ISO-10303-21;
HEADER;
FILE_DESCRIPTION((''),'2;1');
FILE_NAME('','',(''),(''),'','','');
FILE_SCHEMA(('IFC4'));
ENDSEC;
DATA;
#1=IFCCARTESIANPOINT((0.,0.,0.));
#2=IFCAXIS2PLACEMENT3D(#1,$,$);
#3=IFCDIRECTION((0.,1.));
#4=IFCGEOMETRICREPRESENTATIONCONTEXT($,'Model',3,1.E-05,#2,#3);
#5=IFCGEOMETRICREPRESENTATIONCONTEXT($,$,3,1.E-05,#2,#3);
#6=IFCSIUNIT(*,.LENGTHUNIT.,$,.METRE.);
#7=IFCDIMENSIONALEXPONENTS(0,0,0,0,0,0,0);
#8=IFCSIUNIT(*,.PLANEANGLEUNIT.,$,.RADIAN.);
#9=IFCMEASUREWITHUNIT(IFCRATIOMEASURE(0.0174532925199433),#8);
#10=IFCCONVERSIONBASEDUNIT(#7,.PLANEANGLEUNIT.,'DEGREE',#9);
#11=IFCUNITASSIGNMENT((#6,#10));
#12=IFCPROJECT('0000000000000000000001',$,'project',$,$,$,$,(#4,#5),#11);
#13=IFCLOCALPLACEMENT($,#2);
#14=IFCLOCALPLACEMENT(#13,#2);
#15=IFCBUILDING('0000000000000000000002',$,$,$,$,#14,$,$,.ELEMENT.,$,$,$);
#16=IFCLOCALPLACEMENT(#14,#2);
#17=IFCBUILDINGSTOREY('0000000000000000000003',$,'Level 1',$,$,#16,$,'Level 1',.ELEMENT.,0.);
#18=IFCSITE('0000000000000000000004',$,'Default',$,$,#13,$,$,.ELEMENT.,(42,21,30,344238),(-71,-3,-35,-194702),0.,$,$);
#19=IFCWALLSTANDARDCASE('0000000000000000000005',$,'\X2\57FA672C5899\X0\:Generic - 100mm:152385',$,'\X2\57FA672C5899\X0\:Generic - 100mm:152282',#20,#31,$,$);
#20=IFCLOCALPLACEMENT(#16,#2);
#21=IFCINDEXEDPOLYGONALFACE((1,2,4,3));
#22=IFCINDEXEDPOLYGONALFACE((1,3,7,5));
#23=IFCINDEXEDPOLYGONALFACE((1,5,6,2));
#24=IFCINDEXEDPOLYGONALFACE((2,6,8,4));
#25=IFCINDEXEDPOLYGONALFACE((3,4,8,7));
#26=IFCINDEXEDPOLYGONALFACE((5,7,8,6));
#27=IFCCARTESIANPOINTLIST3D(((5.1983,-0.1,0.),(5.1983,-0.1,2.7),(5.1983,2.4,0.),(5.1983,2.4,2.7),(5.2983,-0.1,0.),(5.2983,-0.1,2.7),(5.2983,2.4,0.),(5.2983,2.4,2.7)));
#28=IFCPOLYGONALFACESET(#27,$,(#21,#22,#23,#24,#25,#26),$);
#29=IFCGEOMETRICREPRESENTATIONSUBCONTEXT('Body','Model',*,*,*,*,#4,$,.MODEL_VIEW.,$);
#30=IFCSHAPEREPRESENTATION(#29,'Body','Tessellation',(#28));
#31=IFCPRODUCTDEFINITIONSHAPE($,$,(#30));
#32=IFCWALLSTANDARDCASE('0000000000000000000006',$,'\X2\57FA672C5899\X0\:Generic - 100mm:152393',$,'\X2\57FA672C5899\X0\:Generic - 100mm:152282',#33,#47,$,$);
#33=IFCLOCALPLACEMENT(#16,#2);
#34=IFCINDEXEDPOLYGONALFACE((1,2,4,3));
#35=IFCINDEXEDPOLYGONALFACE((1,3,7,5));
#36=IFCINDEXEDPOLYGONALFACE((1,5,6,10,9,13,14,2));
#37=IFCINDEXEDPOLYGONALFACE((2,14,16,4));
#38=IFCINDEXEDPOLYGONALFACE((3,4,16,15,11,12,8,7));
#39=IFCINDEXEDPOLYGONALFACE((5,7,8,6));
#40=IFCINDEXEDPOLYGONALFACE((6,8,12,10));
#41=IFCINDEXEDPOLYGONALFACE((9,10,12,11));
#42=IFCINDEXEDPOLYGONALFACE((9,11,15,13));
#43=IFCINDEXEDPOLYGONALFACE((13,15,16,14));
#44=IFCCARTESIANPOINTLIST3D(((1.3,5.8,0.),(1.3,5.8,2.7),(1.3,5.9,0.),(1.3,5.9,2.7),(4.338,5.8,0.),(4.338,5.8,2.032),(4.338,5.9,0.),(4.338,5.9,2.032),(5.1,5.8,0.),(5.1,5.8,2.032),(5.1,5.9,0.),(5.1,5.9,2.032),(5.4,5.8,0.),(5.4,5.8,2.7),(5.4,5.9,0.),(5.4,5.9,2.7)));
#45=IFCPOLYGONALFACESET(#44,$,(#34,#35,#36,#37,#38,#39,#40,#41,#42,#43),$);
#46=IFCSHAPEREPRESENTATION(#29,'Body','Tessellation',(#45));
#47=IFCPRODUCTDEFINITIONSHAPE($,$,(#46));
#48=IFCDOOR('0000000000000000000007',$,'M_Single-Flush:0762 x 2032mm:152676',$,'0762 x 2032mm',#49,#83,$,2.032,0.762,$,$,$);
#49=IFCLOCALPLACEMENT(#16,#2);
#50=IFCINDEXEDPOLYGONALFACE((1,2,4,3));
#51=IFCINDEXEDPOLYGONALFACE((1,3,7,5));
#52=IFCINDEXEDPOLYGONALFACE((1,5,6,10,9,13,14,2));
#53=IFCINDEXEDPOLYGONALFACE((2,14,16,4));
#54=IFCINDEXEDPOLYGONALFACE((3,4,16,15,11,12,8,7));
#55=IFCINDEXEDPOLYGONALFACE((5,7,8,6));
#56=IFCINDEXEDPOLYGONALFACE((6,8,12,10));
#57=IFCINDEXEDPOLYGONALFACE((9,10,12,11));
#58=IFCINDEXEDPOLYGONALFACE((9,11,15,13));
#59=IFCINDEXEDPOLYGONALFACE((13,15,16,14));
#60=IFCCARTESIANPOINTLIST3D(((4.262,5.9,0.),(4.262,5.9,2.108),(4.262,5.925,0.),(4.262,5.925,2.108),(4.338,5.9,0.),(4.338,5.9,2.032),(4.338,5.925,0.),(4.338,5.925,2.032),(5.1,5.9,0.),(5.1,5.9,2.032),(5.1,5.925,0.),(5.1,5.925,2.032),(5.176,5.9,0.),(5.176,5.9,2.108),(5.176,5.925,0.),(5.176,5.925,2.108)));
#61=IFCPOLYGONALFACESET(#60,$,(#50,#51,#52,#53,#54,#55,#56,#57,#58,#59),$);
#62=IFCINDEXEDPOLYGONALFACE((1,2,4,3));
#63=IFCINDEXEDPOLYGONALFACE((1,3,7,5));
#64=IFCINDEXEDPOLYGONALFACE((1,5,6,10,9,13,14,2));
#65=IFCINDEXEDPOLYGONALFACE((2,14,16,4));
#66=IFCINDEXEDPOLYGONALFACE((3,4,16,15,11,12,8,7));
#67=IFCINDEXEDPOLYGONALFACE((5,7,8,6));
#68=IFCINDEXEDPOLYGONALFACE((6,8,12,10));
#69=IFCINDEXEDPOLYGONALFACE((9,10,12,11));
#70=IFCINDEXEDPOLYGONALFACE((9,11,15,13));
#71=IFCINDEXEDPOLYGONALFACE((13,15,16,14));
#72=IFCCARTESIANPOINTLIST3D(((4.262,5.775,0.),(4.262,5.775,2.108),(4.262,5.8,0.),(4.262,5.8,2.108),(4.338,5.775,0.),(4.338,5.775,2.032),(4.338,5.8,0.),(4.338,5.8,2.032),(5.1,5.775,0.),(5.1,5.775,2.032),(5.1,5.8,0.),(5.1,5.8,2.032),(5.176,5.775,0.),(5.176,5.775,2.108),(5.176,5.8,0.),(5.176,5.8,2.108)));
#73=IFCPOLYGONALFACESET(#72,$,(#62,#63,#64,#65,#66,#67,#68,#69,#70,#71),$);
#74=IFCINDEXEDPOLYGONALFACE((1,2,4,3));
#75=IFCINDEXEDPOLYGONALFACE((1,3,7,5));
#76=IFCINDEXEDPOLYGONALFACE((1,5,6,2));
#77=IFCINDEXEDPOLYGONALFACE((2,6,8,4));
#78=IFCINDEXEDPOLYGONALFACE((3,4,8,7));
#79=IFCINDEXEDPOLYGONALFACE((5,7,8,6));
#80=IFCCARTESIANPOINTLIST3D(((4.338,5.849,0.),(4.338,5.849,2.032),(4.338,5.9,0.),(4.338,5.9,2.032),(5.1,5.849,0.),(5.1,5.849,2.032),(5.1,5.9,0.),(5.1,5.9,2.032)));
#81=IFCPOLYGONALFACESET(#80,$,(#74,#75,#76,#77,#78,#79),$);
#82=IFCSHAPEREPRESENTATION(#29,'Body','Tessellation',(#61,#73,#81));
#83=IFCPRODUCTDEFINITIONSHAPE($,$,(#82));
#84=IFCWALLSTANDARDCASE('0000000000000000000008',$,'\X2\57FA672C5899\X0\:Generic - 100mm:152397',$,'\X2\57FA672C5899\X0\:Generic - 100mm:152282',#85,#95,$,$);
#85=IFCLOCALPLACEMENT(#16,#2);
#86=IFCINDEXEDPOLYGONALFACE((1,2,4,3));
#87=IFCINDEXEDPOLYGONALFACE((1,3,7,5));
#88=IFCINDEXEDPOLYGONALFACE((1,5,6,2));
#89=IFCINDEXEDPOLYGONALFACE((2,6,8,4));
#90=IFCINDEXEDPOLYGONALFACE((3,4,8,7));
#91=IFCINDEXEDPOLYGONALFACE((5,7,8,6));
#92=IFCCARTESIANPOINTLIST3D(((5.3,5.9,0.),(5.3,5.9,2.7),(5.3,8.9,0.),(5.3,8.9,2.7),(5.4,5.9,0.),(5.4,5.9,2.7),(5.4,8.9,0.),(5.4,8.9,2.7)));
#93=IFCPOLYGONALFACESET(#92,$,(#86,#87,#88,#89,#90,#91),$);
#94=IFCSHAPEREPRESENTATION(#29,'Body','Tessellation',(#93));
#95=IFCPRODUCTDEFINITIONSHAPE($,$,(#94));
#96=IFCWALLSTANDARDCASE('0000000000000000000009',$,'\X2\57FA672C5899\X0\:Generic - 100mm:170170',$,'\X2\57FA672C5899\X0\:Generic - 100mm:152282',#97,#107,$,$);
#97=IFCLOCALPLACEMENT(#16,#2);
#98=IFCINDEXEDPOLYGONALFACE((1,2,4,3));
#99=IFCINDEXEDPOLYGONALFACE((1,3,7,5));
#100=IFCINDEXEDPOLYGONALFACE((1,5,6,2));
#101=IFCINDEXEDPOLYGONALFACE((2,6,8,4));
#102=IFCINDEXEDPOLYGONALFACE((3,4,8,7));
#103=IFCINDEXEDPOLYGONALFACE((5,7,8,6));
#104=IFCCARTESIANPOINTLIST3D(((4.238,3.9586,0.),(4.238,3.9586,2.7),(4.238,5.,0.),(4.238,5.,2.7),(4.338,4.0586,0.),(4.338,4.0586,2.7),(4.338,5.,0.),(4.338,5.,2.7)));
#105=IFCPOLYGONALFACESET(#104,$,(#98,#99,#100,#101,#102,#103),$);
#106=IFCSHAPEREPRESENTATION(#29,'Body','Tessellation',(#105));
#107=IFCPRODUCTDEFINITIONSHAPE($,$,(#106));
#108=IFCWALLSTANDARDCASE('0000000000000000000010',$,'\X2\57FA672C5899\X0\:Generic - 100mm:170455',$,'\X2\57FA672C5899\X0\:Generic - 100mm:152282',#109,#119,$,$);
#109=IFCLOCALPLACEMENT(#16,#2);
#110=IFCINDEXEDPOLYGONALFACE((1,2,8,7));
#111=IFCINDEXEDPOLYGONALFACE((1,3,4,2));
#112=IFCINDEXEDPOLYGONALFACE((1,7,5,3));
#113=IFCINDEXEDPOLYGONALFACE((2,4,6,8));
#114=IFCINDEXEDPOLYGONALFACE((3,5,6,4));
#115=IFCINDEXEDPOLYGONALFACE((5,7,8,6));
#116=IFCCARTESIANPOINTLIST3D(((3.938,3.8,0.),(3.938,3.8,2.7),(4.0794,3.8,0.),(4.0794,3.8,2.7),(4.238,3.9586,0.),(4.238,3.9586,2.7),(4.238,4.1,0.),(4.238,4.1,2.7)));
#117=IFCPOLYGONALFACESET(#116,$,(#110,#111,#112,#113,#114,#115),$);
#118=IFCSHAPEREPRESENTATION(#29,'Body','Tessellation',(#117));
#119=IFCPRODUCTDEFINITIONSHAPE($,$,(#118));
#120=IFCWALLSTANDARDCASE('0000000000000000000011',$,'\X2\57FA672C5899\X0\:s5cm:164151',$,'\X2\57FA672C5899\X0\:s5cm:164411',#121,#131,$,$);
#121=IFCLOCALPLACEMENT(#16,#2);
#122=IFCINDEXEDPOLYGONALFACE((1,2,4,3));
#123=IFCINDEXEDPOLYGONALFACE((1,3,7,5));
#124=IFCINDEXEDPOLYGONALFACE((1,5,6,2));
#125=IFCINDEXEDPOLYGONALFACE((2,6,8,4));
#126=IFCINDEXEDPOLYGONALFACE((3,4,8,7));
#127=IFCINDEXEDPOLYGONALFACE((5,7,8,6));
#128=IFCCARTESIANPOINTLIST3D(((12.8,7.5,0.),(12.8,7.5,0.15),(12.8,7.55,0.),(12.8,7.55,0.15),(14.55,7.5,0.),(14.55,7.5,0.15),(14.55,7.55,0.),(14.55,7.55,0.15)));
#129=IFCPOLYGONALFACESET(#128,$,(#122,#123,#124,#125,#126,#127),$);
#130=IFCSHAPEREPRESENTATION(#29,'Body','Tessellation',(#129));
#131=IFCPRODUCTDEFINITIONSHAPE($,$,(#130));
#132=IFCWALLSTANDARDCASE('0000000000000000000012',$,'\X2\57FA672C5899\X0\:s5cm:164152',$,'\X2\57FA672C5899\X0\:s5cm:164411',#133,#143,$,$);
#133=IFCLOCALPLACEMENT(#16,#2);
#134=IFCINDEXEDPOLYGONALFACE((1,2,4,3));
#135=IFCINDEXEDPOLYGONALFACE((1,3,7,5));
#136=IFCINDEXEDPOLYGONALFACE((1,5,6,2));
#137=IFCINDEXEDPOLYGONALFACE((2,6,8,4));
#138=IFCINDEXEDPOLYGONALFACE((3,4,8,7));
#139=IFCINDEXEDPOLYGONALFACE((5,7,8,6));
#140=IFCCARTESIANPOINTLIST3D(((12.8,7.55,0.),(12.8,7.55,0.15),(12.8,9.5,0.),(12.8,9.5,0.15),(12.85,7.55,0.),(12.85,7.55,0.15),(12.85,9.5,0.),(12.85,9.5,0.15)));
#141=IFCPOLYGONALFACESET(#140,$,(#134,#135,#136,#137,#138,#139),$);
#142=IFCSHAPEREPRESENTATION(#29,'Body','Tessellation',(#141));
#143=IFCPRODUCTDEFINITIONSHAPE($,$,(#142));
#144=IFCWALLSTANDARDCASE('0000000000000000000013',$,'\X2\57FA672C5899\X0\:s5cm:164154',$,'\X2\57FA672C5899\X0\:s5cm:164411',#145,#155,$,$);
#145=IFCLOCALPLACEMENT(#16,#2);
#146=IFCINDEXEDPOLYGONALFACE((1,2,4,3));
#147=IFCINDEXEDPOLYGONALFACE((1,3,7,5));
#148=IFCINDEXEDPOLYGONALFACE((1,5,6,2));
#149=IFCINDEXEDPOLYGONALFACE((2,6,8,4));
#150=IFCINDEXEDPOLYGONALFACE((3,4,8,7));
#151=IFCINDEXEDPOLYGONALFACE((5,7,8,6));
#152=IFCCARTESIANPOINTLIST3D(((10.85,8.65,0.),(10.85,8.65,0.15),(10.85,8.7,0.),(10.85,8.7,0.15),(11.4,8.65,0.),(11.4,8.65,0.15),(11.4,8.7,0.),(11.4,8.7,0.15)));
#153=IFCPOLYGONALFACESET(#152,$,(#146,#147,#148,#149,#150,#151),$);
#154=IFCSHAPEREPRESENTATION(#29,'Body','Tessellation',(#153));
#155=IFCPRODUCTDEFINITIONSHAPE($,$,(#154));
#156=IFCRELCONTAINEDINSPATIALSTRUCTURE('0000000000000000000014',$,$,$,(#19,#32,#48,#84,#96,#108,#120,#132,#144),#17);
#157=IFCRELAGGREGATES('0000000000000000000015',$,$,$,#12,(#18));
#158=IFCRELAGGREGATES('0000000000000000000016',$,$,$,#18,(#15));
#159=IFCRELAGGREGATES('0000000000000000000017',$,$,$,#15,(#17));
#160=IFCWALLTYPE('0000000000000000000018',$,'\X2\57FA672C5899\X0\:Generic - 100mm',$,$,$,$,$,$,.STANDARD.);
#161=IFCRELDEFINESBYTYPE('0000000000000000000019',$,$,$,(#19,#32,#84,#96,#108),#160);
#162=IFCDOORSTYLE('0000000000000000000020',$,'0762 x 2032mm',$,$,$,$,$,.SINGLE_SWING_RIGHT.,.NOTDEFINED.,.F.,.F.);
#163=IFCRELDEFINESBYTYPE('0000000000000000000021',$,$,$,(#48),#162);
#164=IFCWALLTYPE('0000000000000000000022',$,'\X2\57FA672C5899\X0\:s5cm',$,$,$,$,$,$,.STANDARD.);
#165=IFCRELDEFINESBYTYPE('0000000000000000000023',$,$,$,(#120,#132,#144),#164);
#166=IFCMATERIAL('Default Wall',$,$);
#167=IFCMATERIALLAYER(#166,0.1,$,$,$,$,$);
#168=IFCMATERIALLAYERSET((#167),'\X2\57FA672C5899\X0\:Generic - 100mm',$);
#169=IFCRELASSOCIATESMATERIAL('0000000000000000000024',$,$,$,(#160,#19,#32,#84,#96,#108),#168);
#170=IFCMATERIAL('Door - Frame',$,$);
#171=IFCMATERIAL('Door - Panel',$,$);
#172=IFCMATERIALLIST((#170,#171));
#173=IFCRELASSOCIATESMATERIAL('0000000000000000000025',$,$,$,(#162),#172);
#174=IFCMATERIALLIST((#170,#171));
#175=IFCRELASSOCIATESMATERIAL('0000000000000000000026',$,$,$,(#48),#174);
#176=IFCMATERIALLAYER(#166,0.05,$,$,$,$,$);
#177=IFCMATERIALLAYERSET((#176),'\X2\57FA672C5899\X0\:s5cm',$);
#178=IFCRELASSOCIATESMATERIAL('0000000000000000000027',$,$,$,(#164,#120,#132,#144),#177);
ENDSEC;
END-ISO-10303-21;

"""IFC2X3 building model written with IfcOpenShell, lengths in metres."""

from ifc_helpers import new_model, entity, si_unit, converted_unit, direction, frame, frame_2d, origin, origin_2d_with_axis, place, context, subcontext, project, spatial, polyline, rectangle, outline, extrude, clip, bounded_halfspace, source, transform, mapped, material, material_list, layer, layer_set, layer_usage, type_object, type_shapes, element, fill, save


model = new_model("IFC2X3")

# Units and contexts
model_context = context("Model", 3, precision=1e-05, world=origin(), true_north=direction((0.0, 1.0)))
context_of_model = context(None, 3, precision=1e-05, world=origin(), true_north=direction((0.0, 1.0)))
body_context = subcontext(model_context, "Body", "Model", "MODEL_VIEW")
ifc_project = project(units=[si_unit("LENGTHUNIT", "METRE"), converted_unit("PLANEANGLEUNIT", "DEGREE", entity("IfcRatioMeasure", 0.0174532925199433), si_unit("PLANEANGLEUNIT", "RADIAN"), dimensions=[0, 0, 0, 0, 0, 0, 0])], contexts=[model_context, context_of_model])

# Site, building, storey
site_placement = place(None, origin())
site = spatial("IfcSite", under=ifc_project, at=site_placement, Name="Default", CompositionType="ELEMENT", RefLatitude=(42, 21, 30, 344238), RefLongitude=(-71, -3, -35, -194702), RefElevation=0.0)
building_placement = place(site_placement, origin())
building = spatial("IfcBuilding", under=site, at=building_placement, CompositionType="ELEMENT")
storey_placement = place(building_placement, origin())
storey = spatial("IfcBuildingStorey", under=building, at=storey_placement, Name="Level 1", LongName="Level 1", CompositionType="ELEMENT", Elevation=0.0)

# Shared definitions
ifc_material_1 = material(Name="Default Wall")
ifc_material_2 = material(Name="Door - Panel")
ifc_material_3 = material(Name="Door - Frame")

# Wall
ifc_layer_1 = layer(ifc_material_1, 0.1)
ifc_layer_set_1 = layer_set([ifc_layer_1], Name="基本墙:Generic - 100mm")
wall_type_1 = type_object("IfcWallType", Name="基本墙:Generic - 100mm", PredefinedType="STANDARD", material=ifc_layer_set_1)
ifc_layer_usage_1 = layer_usage(ifc_layer_set_1, "AXIS2", "NEGATIVE", 0.05)
wall_1_placement = place(storey_placement, frame((5.2483, -0.1, 0.0), z_axis=(0.0, 0.0, 1.0), x_axis=(0.0, 1.0, 0.0)))
element("IfcWallStandardCase", 1, at=wall_1_placement, inside=storey, type_object=wall_type_1, material=ifc_layer_usage_1, Name="基本墙:Generic - 100mm:152385", ObjectType="基本墙:Generic - 100mm:152282", context=body_context, shape_type="Clipping", body=[
    clip(extrude(rectangle(XDim=2.5, YDim=0.1, at=frame_2d((1.25, 0.0), x_axis=(-1.0, 0.0))), origin(), (0.0, 0.0, 1.0), 3.0), bounded_halfspace(frame((0.0, -0.05, 2.7), z_axis=(0.0, 0.0, -1.0), x_axis=(-1.0, 0.0, 0.0)), True, frame((0.0, -0.05, 2.7), z_axis=(0.0, 0.0, -1.0), x_axis=(-1.0, 0.0, 0.0)), polyline([(0.0, 0.0), (0.0, 0.1), (-2.5, 0.1), (-2.5, 0.0), (0.0, 0.0)]))),
])

# Wall, opening, door
ifc_layer_usage_2 = layer_usage(ifc_layer_set_1, "AXIS2", "NEGATIVE", 0.05)
wall_2_placement = place(storey_placement, frame((5.4, 5.85, 0.0), z_axis=(0.0, 0.0, 1.0), x_axis=(-1.0, 0.0, 0.0)))
wall_2 = element("IfcWallStandardCase", 2, at=wall_2_placement, inside=storey, type_object=wall_type_1, material=ifc_layer_usage_2, Name="基本墙:Generic - 100mm:152393", ObjectType="基本墙:Generic - 100mm:152282", context=body_context, shape_type="Clipping", body=[
    clip(extrude(rectangle(XDim=4.1, YDim=0.1, at=frame_2d((2.05, 0.0), x_axis=(-1.0, 0.0))), origin(), (0.0, 0.0, 1.0), 3.0), bounded_halfspace(frame((0.0, -0.05, 2.7), z_axis=(0.0, 0.0, -1.0), x_axis=(0.0, 1.0, 0.0)), True, frame((0.0, -0.05, 2.7), z_axis=(0.0, 0.0, -1.0), x_axis=(0.0, 1.0, 0.0)), polyline([(0.0, 0.0), (0.1, 0.0), (0.1, 2.3), (0.1, 2.4), (0.1, 4.1), (0.0, 4.1), (0.0, 0.1), (0.0, 0.0)]))),
])
opening_1_placement = place(wall_2_placement, frame((1.062, 0.05, 0.0)))
opening_1 = element("IfcOpeningElement", 3, at=opening_1_placement, cuts=wall_2, ObjectType="Opening", context=body_context, shape_type="SweptSolid", body=[
    extrude(rectangle(XDim=0.762, YDim=2.032, at=frame_2d((1.016, 0.381), x_axis=(0.0, 1.0))), frame((0.0, 0.0, 0.0), z_axis=(0.0, -1.0, 0.0), x_axis=(0.0, 0.0, 1.0)), (0.0, 0.0, 1.0), 0.1),
])
ifc_material_list_1 = material_list([ifc_material_3, ifc_material_2])
ifc_material_list_2 = material_list([ifc_material_3, ifc_material_2])
door_style_1 = type_object("IfcDoorStyle", Name="0762 x 2032mm", ConstructionType="NOTDEFINED", OperationType="SINGLE_SWING_RIGHT", ParameterTakesPrecedence=False, Sizeable=False, material=ifc_material_list_2)
shared_shape_1 = source(origin(), body_context, "Body", "SweptSolid", [
    extrude(outline(polyline([(-0.457, -1.073), (0.457, -1.073), (0.457, 1.035), (0.381, 1.035), (0.381, -0.997), (-0.381, -0.997), (-0.381, 1.035), (-0.457, 1.035), (-0.457, -1.073)])), frame((0.381, 0.1, 1.035), z_axis=(0.0, 1.0, 0.0), x_axis=(1.0, 0.0, 0.0)), (0.0, 0.0, 1.0), 0.025),
    extrude(outline(polyline([(-1.073, -0.457), (1.035, -0.457), (1.035, -0.381), (-0.997, -0.381), (-0.997, 0.381), (1.035, 0.381), (1.035, 0.457), (-1.073, 0.457), (-1.073, -0.457)])), frame((0.381, -0.025, 1.035), z_axis=(0.0, 1.0, 0.0), x_axis=(0.0, 0.0, -1.0)), (0.0, 0.0, 1.0), 0.025),
    extrude(rectangle(XDim=0.051, YDim=0.762, at=origin_2d_with_axis()), frame((0.381, 0.0745, 0.0), z_axis=(0.0, 0.0, 1.0), x_axis=(0.0, 1.0, 0.0)), (0.0, 0.0, 1.0), 2.032),
])
type_shapes(door_style_1, [shared_shape_1])
door_1_placement = place(opening_1_placement, frame((0.0, 0.0, 0.0), z_axis=(0.0, 0.0, 1.0), x_axis=(-1.0, 0.0, 0.0)))
door_1 = element("IfcDoor", 4, at=door_1_placement, inside=storey, type_object=door_style_1, material=ifc_material_list_1, Name="M_Single-Flush:0762 x 2032mm:152676", ObjectType="0762 x 2032mm", OverallHeight=2.032, OverallWidth=0.762, context=body_context, shape_type="MappedRepresentation", body=[
    mapped(shared_shape_1, transform((0.0, 0.0, 0.0), scale=1.0)),
])
fill(opening_1, door_1)

# Walls
ifc_layer_usage_3 = layer_usage(ifc_layer_set_1, "AXIS2", "NEGATIVE", 0.05)
wall_3_placement = place(storey_placement, frame((5.35, 8.9, 0.0), z_axis=(0.0, 0.0, 1.0), x_axis=(0.0, -1.0, 0.0)))
element("IfcWallStandardCase", 5, at=wall_3_placement, inside=storey, type_object=wall_type_1, material=ifc_layer_usage_3, Name="基本墙:Generic - 100mm:152397", ObjectType="基本墙:Generic - 100mm:152282", context=body_context, shape_type="Clipping", body=[
    clip(extrude(rectangle(XDim=3.0, YDim=0.1, at=frame_2d((1.5, 0.0), x_axis=(-1.0, 0.0))), origin(), (0.0, 0.0, 1.0), 3.0), bounded_halfspace(frame((0.0, -0.05, 2.7), z_axis=(0.0, 0.0, -1.0), x_axis=(1.0, 0.0, 0.0)), True, frame((0.0, -0.05, 2.7), z_axis=(0.0, 0.0, -1.0), x_axis=(1.0, 0.0, 0.0)), polyline([(0.0, 0.0), (0.0, -0.1), (3.0, -0.1), (3.0, 0.0), (0.0, 0.0)]))),
])
ifc_layer_usage_4 = layer_usage(ifc_layer_set_1, "AXIS2", "NEGATIVE", 0.05)
wall_4_placement = place(storey_placement, frame((4.288, 3.9586, 0.0), z_axis=(0.0, 0.0, 1.0), x_axis=(0.0, 1.0, 0.0)))
element("IfcWallStandardCase", 6, at=wall_4_placement, inside=storey, type_object=wall_type_1, material=ifc_layer_usage_4, Name="基本墙:Generic - 100mm:170170", ObjectType="基本墙:Generic - 100mm:152282", context=body_context, shape_type="Clipping", body=[
    clip(extrude(outline(polyline([(1.0414, -0.05), (1.0414, 0.05), (0.1414, 0.05), (0.0, 0.05), (0.1, -0.05), (1.0414, -0.05)])), origin(), (0.0, 0.0, 1.0), 2.7), bounded_halfspace(frame((0.1, -0.05, 2.7), z_axis=(0.0, 0.0, -1.0), x_axis=(-1.0, 0.0, 0.0)), True, frame((0.1, -0.05, 2.7)), polyline([(0.0, 0.0), (0.9414, 0.0), (0.9414, 0.1), (0.0414, 0.1), (-0.1, 0.1), (0.0, 0.0)]))),
])
ifc_layer_usage_5 = layer_usage(ifc_layer_set_1, "AXIS2", "NEGATIVE", 0.05)
wall_5_placement = place(storey_placement, frame((3.9734, 3.7646, 0.0), z_axis=(0.0, 0.0, 1.0), x_axis=(0.707107, 0.707107, 0.0)))
element("IfcWallStandardCase", 7, at=wall_5_placement, inside=storey, type_object=wall_type_1, material=ifc_layer_usage_5, Name="基本墙:Generic - 100mm:170455", ObjectType="基本墙:Generic - 100mm:152282", context=body_context, shape_type="Clipping", body=[
    clip(extrude(outline(polyline([(0.3243, -0.05), (0.4243, 0.05), (0.0, 0.05), (0.1, -0.05), (0.3243, -0.05)])), origin(), (0.0, 0.0, 1.0), 2.7), bounded_halfspace(frame((0.1, -0.05, 2.7), z_axis=(0.0, 0.0, -1.0), x_axis=(-0.707107, -0.707107, 0.0)), True, frame((0.1, -0.05, 2.7)), polyline([(0.0, 0.0), (0.2243, 0.0), (0.3243, 0.1), (-0.1, 0.1), (0.0, 0.0)]))),
])
ifc_layer_2 = layer(ifc_material_1, 0.05)
ifc_layer_set_2 = layer_set([ifc_layer_2], Name="基本墙:s5cm")
ifc_layer_usage_6 = layer_usage(ifc_layer_set_2, "AXIS2", "NEGATIVE", 0.025)
wall_type_2 = type_object("IfcWallType", Name="基本墙:s5cm", PredefinedType="STANDARD", material=ifc_layer_set_2)
wall_6_placement = place(storey_placement, frame((14.55, 7.525, 0.0), z_axis=(0.0, 0.0, 1.0), x_axis=(-1.0, 0.0, 0.0)))
element("IfcWallStandardCase", 8, at=wall_6_placement, inside=storey, type_object=wall_type_2, material=ifc_layer_usage_6, Name="基本墙:s5cm:164151", ObjectType="基本墙:s5cm:164411", context=body_context, shape_type="SweptSolid", body=[
    extrude(rectangle(XDim=1.75, YDim=0.05, at=frame_2d((0.875, 0.0), x_axis=(-1.0, 0.0))), origin(), (0.0, 0.0, 1.0), 0.15),
])
ifc_layer_usage_7 = layer_usage(ifc_layer_set_2, "AXIS2", "NEGATIVE", 0.025)
wall_7_placement = place(storey_placement, frame((12.825, 7.55, 0.0), z_axis=(0.0, 0.0, 1.0), x_axis=(0.0, 1.0, 0.0)))
element("IfcWallStandardCase", 9, at=wall_7_placement, inside=storey, type_object=wall_type_2, material=ifc_layer_usage_7, Name="基本墙:s5cm:164152", ObjectType="基本墙:s5cm:164411", context=body_context, shape_type="SweptSolid", body=[
    extrude(rectangle(XDim=1.95, YDim=0.05, at=frame_2d((0.975, 0.0), x_axis=(-1.0, 0.0))), origin(), (0.0, 0.0, 1.0), 0.15),
])
ifc_layer_usage_8 = layer_usage(ifc_layer_set_2, "AXIS2", "NEGATIVE", 0.025)
wall_8_placement = place(storey_placement, frame((11.4, 8.675, 0.0), z_axis=(0.0, 0.0, 1.0), x_axis=(-1.0, 0.0, 0.0)))
element("IfcWallStandardCase", 10, at=wall_8_placement, inside=storey, type_object=wall_type_2, material=ifc_layer_usage_8, Name="基本墙:s5cm:164154", ObjectType="基本墙:s5cm:164411", context=body_context, shape_type="SweptSolid", body=[
    extrude(rectangle(XDim=0.55, YDim=0.05, at=frame_2d((0.275, 0.0), x_axis=(-1.0, 0.0))), origin(), (0.0, 0.0, 1.0), 0.15),
])

save(model, "model.ifc")
